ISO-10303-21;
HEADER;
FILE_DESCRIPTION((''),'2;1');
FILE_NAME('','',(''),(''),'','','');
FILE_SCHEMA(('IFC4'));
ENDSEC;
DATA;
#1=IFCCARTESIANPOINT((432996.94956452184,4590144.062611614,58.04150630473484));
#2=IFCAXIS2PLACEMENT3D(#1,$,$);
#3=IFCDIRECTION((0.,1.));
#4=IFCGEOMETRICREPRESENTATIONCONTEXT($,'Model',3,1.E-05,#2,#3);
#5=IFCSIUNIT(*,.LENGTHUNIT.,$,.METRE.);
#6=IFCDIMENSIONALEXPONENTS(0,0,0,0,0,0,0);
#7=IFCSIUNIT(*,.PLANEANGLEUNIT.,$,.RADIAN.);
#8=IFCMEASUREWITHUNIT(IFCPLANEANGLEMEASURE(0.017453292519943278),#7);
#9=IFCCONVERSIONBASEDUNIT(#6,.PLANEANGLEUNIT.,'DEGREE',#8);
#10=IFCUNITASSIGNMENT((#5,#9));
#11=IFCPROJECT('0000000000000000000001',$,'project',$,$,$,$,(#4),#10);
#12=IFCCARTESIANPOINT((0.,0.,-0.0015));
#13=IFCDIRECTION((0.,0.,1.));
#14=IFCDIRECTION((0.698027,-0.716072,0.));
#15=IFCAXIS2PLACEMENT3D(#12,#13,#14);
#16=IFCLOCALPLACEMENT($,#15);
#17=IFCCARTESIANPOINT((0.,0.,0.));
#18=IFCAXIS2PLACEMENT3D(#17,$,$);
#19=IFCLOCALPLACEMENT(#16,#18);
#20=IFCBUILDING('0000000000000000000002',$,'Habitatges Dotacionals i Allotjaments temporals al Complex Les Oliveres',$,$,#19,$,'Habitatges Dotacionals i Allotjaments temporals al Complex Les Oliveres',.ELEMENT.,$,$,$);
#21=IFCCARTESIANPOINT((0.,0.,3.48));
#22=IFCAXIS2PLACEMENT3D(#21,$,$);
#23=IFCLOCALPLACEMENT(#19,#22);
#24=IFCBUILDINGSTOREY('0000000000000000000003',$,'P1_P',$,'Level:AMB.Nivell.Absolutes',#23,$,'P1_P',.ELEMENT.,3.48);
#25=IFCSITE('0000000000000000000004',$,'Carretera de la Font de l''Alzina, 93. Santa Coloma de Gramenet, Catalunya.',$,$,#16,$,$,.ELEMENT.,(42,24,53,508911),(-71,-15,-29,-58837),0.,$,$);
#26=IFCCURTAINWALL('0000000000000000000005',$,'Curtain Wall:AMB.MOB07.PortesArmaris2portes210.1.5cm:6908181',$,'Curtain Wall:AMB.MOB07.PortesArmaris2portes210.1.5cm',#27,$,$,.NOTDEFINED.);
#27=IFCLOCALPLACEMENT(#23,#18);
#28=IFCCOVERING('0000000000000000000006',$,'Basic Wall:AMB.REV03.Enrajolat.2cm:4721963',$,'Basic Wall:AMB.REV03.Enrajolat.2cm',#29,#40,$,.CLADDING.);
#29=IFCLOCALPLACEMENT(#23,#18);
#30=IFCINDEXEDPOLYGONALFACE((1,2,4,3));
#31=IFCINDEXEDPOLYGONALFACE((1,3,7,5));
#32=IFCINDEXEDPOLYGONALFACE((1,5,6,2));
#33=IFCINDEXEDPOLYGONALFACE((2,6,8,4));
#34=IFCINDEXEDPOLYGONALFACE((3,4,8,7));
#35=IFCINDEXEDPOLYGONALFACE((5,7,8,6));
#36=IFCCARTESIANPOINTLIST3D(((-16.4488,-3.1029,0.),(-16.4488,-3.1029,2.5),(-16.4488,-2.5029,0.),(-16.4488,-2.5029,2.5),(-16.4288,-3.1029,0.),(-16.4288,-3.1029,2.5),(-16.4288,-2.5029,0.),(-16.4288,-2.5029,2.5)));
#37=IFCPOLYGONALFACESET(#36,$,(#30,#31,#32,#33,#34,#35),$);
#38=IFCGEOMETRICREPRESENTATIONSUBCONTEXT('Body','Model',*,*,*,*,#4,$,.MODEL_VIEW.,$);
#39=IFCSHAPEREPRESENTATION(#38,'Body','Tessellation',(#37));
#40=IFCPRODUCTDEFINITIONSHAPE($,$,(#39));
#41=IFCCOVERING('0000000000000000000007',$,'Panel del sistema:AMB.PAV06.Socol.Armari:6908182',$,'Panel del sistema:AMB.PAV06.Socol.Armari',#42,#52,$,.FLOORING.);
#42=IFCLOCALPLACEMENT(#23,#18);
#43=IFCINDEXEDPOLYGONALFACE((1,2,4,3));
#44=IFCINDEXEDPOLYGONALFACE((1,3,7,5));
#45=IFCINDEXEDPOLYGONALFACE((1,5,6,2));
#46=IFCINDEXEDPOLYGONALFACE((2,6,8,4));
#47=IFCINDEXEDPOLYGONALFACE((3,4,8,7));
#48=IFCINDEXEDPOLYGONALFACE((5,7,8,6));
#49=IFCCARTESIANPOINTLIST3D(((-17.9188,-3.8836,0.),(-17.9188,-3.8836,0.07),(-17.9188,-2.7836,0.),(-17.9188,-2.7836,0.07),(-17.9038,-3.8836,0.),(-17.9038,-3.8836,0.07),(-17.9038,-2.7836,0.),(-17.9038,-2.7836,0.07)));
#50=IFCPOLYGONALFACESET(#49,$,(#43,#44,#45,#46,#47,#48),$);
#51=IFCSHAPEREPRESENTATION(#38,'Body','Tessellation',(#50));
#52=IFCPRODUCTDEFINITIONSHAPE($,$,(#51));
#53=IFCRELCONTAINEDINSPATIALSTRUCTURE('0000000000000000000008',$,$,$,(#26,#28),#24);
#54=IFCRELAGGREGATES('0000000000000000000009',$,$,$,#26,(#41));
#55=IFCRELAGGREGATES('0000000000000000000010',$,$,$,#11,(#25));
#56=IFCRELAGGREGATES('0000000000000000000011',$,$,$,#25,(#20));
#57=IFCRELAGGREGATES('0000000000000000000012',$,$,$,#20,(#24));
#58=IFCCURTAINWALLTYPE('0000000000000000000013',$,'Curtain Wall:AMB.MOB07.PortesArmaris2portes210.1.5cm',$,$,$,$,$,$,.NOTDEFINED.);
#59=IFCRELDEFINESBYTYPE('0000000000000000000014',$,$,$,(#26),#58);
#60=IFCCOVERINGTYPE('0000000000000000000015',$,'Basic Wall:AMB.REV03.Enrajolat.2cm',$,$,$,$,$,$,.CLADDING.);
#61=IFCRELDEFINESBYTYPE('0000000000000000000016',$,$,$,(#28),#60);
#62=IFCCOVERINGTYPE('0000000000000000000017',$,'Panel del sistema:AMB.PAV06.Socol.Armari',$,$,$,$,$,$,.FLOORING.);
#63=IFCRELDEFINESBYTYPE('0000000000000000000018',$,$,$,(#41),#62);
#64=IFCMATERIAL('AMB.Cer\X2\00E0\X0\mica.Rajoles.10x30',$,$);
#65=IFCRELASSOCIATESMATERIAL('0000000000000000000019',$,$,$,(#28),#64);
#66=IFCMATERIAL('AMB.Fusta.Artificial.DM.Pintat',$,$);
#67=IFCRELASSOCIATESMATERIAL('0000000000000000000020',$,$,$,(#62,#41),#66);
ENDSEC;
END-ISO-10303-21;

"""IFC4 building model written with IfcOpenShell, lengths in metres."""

from ifc_helpers import new_model, entity, si_unit, converted_unit, direction, frame, origin, place, context, subcontext, project, spatial, indexed_curve, outline, extrude, source, transform, mapped, material, type_object, type_shapes, element, aggregate, save


model = new_model("IFC4")

# Units and contexts
model_context = context("Model", 3, precision=1e-05, world=frame((432996.94956452184, 4590144.062611614, 58.04150630473484)), true_north=direction((0.0, 1.0)))
body_context = subcontext(model_context, "Body", "Model", "MODEL_VIEW")
ifc_project = project(units=[si_unit("LENGTHUNIT", "METRE"), converted_unit("PLANEANGLEUNIT", "DEGREE", entity("IfcPlaneAngleMeasure", 0.017453292519943278), si_unit("PLANEANGLEUNIT", "RADIAN"), dimensions=[0, 0, 0, 0, 0, 0, 0])], contexts=[model_context])

# Site, building, storey
site_placement = place(None, frame((0.0, 0.0, -0.0015), z_axis=(0.0, 0.0, 1.0), x_axis=(0.698027, -0.716072, 0.0)))
site = spatial("IfcSite", under=ifc_project, at=site_placement, Name="Carretera de la Font de l'Alzina, 93. Santa Coloma de Gramenet, Catalunya.", CompositionType="ELEMENT", RefLatitude=(42, 24, 53, 508911), RefLongitude=(-71, -15, -29, -58837), RefElevation=0.0)
building_placement = place(site_placement, origin())
building = spatial("IfcBuilding", under=site, at=building_placement, Name="Habitatges Dotacionals i Allotjaments temporals al Complex Les Oliveres", LongName="Habitatges Dotacionals i Allotjaments temporals al Complex Les Oliveres", CompositionType="ELEMENT")
storey_placement = place(building_placement, frame((0.0, 0.0, 3.48)))
storey = spatial("IfcBuildingStorey", under=building, at=storey_placement, Name="P1_P", ObjectType="Level:AMB.Nivell.Absolutes", LongName="P1_P", CompositionType="ELEMENT", Elevation=3.48)

# Curtain wall
curtain_wall_type_1 = type_object("IfcCurtainWallType", Name="Curtain Wall:AMB.MOB07.PortesArmaris2portes210.1.5cm", PredefinedType="NOTDEFINED")
curtain_wall_1_placement = place(storey_placement, frame((0.0, 0.0, -3.48)))
curtain_wall_1 = element("IfcCurtainWall", 1, at=curtain_wall_1_placement, inside=storey, type_object=curtain_wall_type_1, Name="Curtain Wall:AMB.MOB07.PortesArmaris2portes210.1.5cm:6908181", ObjectType="Curtain Wall:AMB.MOB07.PortesArmaris2portes210.1.5cm", PredefinedType="NOTDEFINED")
ifc_material_1 = material(Name="AMB.Fusta.Artificial.DM.Pintat")

# Covering
ifc_material_2 = material(Name="AMB.Ceràmica.Rajoles.10x30")
covering_type_1 = type_object("IfcCoveringType", Name="Basic Wall:AMB.REV03.Enrajolat.2cm", PredefinedType="CLADDING")
covering_1_placement = place(storey_placement, frame((-16.4388, -2.5029, 0.0), z_axis=(0.0, 0.0, 1.0), x_axis=(0.0, -1.0, 0.0)))
element("IfcCovering", 2, at=covering_1_placement, inside=storey, type_object=covering_type_1, material=ifc_material_2, Name="Basic Wall:AMB.REV03.Enrajolat.2cm:4721963", ObjectType="Basic Wall:AMB.REV03.Enrajolat.2cm", PredefinedType="CLADDING", context=body_context, shape_type="SweptSolid", body=[
    extrude(outline(indexed_curve([(0.6, 0.01), (0.0, 0.01), (0.0, -0.01), (0.6, -0.01), (0.6, 0.01)], self_intersect=False)), origin(), (0.0, 0.0, 1.0), 2.5),
])

# Covering
covering_type_2 = type_object("IfcCoveringType", Name="Panel del sistema:AMB.PAV06.Socol.Armari", PredefinedType="FLOORING", material=ifc_material_1)
shared_shape_1 = source(origin(), body_context, "Body", "SweptSolid", [
    extrude(outline(indexed_curve([(-0.0075, -0.55), (0.0075, -0.55), (0.0075, 0.55), (-0.0075, 0.55), (-0.0075, -0.55)], self_intersect=False)), frame((0.0, -0.0075, 0.0), z_axis=(0.0, 0.0, 1.0), x_axis=(0.0, 1.0, 0.0)), (0.0, 0.0, 1.0), 0.07),
])
type_shapes(covering_type_2, [shared_shape_1])
covering_2_placement = place(storey_placement, frame((-17.9038, -3.3336, 0.0), z_axis=(0.0, 0.0, 1.0), x_axis=(0.0, -1.0, 0.0)))
covering_2 = element("IfcCovering", 3, at=covering_2_placement, type_object=covering_type_2, material=ifc_material_1, Name="Panel del sistema:AMB.PAV06.Socol.Armari:6908182", ObjectType="Panel del sistema:AMB.PAV06.Socol.Armari", PredefinedType="FLOORING", context=body_context, shape_type="MappedRepresentation", body=[
    mapped(shared_shape_1, transform((0.0, 0.0, 0.0), scale=1.0)),
])
aggregate(curtain_wall_1, [covering_2])

save(model, "model.ifc")
